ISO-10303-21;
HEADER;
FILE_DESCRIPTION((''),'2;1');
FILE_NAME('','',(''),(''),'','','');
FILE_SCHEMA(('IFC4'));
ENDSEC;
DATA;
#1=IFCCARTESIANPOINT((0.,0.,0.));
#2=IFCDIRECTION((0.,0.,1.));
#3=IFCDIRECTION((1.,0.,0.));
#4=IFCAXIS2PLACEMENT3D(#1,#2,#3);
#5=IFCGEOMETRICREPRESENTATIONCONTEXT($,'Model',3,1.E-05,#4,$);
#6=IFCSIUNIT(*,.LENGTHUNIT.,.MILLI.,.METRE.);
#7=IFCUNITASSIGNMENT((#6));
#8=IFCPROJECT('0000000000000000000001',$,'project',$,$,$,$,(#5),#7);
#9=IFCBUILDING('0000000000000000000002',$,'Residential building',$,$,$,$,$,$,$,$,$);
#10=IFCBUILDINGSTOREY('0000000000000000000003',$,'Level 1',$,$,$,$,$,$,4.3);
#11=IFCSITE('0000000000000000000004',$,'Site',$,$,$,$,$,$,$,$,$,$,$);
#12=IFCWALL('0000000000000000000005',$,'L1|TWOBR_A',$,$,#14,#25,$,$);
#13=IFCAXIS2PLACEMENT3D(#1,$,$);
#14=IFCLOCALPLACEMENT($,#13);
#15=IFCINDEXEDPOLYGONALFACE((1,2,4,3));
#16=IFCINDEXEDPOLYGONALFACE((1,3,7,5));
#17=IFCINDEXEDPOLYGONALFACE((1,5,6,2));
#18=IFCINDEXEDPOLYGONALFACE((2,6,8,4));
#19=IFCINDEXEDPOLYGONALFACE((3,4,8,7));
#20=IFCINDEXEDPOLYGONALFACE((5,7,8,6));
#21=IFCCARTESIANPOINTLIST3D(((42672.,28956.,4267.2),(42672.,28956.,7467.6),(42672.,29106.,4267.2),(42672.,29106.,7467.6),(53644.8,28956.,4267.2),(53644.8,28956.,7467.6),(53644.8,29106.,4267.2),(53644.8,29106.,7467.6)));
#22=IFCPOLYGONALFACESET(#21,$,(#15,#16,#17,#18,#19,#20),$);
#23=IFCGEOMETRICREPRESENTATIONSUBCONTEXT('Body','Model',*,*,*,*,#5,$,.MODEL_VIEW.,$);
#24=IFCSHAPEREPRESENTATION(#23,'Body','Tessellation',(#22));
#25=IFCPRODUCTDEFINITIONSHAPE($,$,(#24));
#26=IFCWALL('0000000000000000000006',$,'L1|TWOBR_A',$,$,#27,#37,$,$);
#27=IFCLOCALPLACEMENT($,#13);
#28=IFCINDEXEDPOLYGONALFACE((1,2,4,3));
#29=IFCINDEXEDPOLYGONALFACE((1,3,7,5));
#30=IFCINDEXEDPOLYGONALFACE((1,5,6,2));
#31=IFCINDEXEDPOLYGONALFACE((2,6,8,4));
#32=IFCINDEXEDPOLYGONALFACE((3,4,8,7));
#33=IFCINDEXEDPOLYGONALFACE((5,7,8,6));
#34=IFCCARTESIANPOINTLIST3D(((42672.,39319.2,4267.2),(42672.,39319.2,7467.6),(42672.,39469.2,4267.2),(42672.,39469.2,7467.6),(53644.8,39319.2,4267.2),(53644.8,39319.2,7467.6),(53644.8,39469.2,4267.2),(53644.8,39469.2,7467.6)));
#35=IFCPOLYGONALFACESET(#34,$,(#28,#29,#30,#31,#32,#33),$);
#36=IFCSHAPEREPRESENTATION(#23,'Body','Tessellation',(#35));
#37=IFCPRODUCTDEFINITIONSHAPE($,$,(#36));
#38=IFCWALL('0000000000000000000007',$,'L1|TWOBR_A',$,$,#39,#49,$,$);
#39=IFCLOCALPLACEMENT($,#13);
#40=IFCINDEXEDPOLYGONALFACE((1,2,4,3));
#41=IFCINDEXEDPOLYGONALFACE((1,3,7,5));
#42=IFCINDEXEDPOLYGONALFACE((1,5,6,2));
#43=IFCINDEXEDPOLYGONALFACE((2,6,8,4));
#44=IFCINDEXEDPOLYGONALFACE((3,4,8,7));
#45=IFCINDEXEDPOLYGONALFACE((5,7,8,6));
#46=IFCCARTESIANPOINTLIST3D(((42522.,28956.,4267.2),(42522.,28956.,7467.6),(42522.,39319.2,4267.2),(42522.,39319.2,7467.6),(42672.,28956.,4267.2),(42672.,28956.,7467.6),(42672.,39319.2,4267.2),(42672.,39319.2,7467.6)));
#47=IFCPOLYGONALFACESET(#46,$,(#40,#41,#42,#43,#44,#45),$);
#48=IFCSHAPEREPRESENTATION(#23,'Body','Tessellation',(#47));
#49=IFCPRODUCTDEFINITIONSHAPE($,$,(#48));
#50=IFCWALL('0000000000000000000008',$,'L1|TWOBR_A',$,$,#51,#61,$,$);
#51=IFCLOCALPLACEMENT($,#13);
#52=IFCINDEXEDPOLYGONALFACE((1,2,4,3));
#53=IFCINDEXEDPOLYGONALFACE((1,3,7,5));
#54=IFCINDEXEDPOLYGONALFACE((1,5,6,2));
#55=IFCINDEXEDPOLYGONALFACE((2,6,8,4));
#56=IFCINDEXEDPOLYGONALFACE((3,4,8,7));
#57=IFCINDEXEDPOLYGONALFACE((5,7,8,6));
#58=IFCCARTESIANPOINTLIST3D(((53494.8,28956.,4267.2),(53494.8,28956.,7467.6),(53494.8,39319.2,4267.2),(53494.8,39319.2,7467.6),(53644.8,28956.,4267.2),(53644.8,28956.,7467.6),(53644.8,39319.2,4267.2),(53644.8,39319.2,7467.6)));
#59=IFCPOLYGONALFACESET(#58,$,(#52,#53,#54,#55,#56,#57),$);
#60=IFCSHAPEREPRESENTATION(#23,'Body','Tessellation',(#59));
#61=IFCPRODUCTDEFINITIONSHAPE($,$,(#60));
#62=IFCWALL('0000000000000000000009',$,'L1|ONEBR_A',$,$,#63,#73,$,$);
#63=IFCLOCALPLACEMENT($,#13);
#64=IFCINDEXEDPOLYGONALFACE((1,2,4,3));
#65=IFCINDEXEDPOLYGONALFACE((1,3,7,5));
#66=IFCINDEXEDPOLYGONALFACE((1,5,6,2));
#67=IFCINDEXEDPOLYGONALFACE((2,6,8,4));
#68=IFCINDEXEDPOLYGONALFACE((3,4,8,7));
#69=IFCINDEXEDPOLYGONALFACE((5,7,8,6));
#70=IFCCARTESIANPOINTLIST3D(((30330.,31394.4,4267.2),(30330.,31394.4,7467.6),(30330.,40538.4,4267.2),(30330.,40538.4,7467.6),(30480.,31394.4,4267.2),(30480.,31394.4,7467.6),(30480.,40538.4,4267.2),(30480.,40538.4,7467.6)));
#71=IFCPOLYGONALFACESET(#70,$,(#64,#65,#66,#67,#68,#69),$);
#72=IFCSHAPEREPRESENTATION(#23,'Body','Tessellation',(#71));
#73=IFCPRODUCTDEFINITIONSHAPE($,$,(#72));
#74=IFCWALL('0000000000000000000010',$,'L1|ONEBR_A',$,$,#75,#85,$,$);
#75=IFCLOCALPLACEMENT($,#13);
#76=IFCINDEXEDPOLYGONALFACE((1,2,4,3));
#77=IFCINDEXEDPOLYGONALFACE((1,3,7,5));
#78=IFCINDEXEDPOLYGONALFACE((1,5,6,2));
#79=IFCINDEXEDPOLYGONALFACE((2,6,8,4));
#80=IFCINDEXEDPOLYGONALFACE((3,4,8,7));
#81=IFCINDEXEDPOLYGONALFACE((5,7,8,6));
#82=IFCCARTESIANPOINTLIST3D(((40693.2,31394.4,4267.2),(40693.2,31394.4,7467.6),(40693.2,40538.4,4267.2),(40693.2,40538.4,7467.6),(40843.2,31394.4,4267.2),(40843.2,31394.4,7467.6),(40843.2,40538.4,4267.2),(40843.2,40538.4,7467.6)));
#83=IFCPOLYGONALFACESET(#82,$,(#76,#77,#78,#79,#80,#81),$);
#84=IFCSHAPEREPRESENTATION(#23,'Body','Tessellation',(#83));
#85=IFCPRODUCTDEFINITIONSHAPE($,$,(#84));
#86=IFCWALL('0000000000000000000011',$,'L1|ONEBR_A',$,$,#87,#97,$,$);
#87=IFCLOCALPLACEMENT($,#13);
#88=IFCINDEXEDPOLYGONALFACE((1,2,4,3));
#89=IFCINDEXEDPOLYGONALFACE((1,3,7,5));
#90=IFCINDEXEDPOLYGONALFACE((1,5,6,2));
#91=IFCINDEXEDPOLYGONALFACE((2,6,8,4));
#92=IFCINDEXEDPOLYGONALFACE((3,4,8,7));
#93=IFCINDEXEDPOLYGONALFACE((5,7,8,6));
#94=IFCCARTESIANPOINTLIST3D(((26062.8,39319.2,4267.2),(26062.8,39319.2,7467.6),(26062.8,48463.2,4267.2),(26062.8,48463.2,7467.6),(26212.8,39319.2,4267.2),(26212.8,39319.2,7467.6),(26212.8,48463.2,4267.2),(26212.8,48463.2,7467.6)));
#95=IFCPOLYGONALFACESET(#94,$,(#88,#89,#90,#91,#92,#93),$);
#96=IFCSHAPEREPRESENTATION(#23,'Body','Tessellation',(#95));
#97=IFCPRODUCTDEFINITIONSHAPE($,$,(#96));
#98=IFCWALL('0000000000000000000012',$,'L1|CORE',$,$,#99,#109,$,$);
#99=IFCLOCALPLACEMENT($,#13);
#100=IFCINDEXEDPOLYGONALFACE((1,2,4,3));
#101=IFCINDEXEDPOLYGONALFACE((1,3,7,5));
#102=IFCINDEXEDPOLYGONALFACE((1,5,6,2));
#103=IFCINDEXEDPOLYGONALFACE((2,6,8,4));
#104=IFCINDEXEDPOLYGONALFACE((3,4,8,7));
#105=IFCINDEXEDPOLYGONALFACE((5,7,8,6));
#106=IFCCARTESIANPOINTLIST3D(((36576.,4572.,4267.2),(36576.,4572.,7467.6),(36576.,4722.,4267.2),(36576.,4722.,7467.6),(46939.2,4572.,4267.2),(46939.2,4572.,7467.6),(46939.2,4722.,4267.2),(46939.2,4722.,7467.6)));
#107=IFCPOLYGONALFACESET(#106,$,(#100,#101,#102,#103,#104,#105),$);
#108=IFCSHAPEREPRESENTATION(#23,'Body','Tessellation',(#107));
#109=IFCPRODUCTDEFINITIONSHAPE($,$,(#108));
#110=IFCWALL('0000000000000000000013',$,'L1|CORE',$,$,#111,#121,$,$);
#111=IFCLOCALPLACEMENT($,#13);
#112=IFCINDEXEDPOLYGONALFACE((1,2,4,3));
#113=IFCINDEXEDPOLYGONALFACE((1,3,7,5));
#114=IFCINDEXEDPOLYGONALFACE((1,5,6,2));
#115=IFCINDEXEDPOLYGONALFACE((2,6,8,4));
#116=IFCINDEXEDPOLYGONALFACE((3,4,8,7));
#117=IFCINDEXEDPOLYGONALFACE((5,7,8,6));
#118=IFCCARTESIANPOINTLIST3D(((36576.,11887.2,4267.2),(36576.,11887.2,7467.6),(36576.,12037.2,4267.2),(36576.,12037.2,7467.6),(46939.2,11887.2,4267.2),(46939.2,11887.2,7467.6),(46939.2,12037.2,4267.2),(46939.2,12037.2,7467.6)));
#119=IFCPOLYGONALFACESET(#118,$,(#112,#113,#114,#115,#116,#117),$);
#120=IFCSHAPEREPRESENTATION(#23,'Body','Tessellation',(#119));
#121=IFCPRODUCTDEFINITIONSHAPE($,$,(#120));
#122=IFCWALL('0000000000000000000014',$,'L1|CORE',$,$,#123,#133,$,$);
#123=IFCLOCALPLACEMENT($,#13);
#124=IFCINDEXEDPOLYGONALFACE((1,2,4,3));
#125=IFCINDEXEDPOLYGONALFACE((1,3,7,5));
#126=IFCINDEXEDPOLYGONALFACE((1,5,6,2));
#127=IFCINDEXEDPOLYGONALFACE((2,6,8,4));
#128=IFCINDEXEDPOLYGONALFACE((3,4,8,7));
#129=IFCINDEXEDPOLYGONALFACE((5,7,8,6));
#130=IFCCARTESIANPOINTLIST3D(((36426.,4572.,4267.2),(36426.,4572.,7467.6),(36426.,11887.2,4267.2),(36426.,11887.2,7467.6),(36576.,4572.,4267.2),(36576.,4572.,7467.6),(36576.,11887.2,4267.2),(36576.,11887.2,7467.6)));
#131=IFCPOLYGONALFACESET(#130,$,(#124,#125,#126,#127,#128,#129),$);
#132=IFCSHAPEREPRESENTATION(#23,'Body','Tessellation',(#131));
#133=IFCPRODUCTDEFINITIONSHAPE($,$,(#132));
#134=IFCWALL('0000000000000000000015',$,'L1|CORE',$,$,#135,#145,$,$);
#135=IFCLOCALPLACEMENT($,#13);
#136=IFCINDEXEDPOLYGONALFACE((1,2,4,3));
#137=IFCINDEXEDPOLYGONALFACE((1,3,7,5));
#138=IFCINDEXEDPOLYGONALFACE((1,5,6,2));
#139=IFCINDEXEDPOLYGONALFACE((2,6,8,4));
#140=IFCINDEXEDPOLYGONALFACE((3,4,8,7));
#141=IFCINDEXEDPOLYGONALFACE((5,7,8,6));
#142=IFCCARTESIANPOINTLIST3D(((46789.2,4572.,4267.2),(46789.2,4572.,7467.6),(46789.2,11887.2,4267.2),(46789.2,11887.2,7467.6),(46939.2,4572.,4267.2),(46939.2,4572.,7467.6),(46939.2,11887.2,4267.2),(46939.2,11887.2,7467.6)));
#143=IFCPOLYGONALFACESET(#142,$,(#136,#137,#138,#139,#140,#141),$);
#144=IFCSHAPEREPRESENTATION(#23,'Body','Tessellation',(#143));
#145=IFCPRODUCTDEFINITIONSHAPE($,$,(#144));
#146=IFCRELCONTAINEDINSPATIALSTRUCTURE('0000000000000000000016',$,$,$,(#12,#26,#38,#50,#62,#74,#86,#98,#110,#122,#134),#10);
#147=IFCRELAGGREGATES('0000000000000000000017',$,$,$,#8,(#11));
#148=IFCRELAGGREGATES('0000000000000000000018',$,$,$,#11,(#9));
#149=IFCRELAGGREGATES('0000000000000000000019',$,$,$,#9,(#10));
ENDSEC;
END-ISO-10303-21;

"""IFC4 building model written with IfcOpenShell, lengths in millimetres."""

from ifc_helpers import new_model, si_unit, frame, origin_with_axes, place, context, subcontext, project, spatial, indexed_curve, outline, extrude, element, save


model = new_model("IFC4")

# Units and contexts
model_context = context("Model", 3, precision=1e-05, world=origin_with_axes())
body_context = subcontext(model_context, "Body", "Model", "MODEL_VIEW")
ifc_project = project(units=[si_unit("LENGTHUNIT", "METRE", prefix="MILLI")], contexts=[model_context])

# Site, building, storey
site = spatial("IfcSite", under=ifc_project, Name="Site")
building = spatial("IfcBuilding", under=site, Name="Residential building")
storey = spatial("IfcBuildingStorey", under=building, Name="Level 1", Elevation=4.3)

# Walls
for number, where, z_axis, x_axis, name in (
    (1, (42672.0, 28956.0, 4267.2), (0.0, 0.0, 1.0), (1.0, 0.0, 0.0), "L1|TWOBR_A"),
    (2, (42672.0, 39319.2, 4267.2), (0.0, 0.0, 1.0), (1.0, 0.0, 0.0), "L1|TWOBR_A"),
):
    element("IfcWall", number, at=place(None, frame(where, z_axis=z_axis, x_axis=x_axis)), inside=storey, Name=name, context=body_context, shape_type="SweptSolid", body=[
        extrude(outline(indexed_curve([(0.0, 0.0), (0.0, 150.0), (10972.8, 150.0), (10972.8, 0.0), (0.0, 0.0)], self_intersect=False)), origin_with_axes(), (0.0, 0.0, 1.0), 3200.4),
    ])
for number, where, z_axis, x_axis, name in (
    (3, (42672.0, 28956.0, 4267.2), (0.0, 0.0, 1.0), (0.0, 1.0, 0.0), "L1|TWOBR_A"),
    (4, (53644.8, 28956.0, 4267.2), (0.0, 0.0, 1.0), (0.0, 1.0, 0.0), "L1|TWOBR_A"),
):
    element("IfcWall", number, at=place(None, frame(where, z_axis=z_axis, x_axis=x_axis)), inside=storey, Name=name, context=body_context, shape_type="SweptSolid", body=[
        extrude(outline(indexed_curve([(0.0, 0.0), (0.0, 150.0), (10363.2, 150.0), (10363.2, 0.0), (0.0, 0.0)], self_intersect=False)), origin_with_axes(), (0.0, 0.0, 1.0), 3200.4),
    ])
for number, where, z_axis, x_axis, name in (
    (5, (30480.0, 31394.4, 4267.2), (0.0, 0.0, 1.0), (0.0, 1.0, 0.0), "L1|ONEBR_A"),
    (6, (40843.2, 31394.4, 4267.2), (0.0, 0.0, 1.0), (0.0, 1.0, 0.0), "L1|ONEBR_A"),
    (7, (26212.8, 39319.2, 4267.2), (0.0, 0.0, 1.0), (0.0, 1.0, 0.0), "L1|ONEBR_A"),
):
    element("IfcWall", number, at=place(None, frame(where, z_axis=z_axis, x_axis=x_axis)), inside=storey, Name=name, context=body_context, shape_type="SweptSolid", body=[
        extrude(outline(indexed_curve([(0.0, 0.0), (0.0, 150.0), (9144.0, 150.0), (9144.0, 0.0), (0.0, 0.0)], self_intersect=False)), origin_with_axes(), (0.0, 0.0, 1.0), 3200.4),
    ])
for number, where, z_axis, x_axis, name in (
    (8, (36576.0, 4572.0, 4267.2), (0.0, 0.0, 1.0), (1.0, 0.0, 0.0), "L1|CORE"),
    (9, (36576.0, 11887.2, 4267.2), (0.0, 0.0, 1.0), (1.0, 0.0, 0.0), "L1|CORE"),
):
    element("IfcWall", number, at=place(None, frame(where, z_axis=z_axis, x_axis=x_axis)), inside=storey, Name=name, context=body_context, shape_type="SweptSolid", body=[
        extrude(outline(indexed_curve([(0.0, 0.0), (0.0, 150.0), (10363.2, 150.0), (10363.2, 0.0), (0.0, 0.0)], self_intersect=False)), origin_with_axes(), (0.0, 0.0, 1.0), 3200.4),
    ])
for number, where, z_axis, x_axis, name in (
    (10, (36576.0, 4572.0, 4267.2), (0.0, 0.0, 1.0), (0.0, 1.0, 0.0), "L1|CORE"),
    (11, (46939.2, 4572.0, 4267.2), (0.0, 0.0, 1.0), (0.0, 1.0, 0.0), "L1|CORE"),
):
    element("IfcWall", number, at=place(None, frame(where, z_axis=z_axis, x_axis=x_axis)), inside=storey, Name=name, context=body_context, shape_type="SweptSolid", body=[
        extrude(outline(indexed_curve([(0.0, 0.0), (0.0, 150.0), (7315.2, 150.0), (7315.2, 0.0), (0.0, 0.0)], self_intersect=False)), origin_with_axes(), (0.0, 0.0, 1.0), 3200.4),
    ])

save(model, "model.ifc")
